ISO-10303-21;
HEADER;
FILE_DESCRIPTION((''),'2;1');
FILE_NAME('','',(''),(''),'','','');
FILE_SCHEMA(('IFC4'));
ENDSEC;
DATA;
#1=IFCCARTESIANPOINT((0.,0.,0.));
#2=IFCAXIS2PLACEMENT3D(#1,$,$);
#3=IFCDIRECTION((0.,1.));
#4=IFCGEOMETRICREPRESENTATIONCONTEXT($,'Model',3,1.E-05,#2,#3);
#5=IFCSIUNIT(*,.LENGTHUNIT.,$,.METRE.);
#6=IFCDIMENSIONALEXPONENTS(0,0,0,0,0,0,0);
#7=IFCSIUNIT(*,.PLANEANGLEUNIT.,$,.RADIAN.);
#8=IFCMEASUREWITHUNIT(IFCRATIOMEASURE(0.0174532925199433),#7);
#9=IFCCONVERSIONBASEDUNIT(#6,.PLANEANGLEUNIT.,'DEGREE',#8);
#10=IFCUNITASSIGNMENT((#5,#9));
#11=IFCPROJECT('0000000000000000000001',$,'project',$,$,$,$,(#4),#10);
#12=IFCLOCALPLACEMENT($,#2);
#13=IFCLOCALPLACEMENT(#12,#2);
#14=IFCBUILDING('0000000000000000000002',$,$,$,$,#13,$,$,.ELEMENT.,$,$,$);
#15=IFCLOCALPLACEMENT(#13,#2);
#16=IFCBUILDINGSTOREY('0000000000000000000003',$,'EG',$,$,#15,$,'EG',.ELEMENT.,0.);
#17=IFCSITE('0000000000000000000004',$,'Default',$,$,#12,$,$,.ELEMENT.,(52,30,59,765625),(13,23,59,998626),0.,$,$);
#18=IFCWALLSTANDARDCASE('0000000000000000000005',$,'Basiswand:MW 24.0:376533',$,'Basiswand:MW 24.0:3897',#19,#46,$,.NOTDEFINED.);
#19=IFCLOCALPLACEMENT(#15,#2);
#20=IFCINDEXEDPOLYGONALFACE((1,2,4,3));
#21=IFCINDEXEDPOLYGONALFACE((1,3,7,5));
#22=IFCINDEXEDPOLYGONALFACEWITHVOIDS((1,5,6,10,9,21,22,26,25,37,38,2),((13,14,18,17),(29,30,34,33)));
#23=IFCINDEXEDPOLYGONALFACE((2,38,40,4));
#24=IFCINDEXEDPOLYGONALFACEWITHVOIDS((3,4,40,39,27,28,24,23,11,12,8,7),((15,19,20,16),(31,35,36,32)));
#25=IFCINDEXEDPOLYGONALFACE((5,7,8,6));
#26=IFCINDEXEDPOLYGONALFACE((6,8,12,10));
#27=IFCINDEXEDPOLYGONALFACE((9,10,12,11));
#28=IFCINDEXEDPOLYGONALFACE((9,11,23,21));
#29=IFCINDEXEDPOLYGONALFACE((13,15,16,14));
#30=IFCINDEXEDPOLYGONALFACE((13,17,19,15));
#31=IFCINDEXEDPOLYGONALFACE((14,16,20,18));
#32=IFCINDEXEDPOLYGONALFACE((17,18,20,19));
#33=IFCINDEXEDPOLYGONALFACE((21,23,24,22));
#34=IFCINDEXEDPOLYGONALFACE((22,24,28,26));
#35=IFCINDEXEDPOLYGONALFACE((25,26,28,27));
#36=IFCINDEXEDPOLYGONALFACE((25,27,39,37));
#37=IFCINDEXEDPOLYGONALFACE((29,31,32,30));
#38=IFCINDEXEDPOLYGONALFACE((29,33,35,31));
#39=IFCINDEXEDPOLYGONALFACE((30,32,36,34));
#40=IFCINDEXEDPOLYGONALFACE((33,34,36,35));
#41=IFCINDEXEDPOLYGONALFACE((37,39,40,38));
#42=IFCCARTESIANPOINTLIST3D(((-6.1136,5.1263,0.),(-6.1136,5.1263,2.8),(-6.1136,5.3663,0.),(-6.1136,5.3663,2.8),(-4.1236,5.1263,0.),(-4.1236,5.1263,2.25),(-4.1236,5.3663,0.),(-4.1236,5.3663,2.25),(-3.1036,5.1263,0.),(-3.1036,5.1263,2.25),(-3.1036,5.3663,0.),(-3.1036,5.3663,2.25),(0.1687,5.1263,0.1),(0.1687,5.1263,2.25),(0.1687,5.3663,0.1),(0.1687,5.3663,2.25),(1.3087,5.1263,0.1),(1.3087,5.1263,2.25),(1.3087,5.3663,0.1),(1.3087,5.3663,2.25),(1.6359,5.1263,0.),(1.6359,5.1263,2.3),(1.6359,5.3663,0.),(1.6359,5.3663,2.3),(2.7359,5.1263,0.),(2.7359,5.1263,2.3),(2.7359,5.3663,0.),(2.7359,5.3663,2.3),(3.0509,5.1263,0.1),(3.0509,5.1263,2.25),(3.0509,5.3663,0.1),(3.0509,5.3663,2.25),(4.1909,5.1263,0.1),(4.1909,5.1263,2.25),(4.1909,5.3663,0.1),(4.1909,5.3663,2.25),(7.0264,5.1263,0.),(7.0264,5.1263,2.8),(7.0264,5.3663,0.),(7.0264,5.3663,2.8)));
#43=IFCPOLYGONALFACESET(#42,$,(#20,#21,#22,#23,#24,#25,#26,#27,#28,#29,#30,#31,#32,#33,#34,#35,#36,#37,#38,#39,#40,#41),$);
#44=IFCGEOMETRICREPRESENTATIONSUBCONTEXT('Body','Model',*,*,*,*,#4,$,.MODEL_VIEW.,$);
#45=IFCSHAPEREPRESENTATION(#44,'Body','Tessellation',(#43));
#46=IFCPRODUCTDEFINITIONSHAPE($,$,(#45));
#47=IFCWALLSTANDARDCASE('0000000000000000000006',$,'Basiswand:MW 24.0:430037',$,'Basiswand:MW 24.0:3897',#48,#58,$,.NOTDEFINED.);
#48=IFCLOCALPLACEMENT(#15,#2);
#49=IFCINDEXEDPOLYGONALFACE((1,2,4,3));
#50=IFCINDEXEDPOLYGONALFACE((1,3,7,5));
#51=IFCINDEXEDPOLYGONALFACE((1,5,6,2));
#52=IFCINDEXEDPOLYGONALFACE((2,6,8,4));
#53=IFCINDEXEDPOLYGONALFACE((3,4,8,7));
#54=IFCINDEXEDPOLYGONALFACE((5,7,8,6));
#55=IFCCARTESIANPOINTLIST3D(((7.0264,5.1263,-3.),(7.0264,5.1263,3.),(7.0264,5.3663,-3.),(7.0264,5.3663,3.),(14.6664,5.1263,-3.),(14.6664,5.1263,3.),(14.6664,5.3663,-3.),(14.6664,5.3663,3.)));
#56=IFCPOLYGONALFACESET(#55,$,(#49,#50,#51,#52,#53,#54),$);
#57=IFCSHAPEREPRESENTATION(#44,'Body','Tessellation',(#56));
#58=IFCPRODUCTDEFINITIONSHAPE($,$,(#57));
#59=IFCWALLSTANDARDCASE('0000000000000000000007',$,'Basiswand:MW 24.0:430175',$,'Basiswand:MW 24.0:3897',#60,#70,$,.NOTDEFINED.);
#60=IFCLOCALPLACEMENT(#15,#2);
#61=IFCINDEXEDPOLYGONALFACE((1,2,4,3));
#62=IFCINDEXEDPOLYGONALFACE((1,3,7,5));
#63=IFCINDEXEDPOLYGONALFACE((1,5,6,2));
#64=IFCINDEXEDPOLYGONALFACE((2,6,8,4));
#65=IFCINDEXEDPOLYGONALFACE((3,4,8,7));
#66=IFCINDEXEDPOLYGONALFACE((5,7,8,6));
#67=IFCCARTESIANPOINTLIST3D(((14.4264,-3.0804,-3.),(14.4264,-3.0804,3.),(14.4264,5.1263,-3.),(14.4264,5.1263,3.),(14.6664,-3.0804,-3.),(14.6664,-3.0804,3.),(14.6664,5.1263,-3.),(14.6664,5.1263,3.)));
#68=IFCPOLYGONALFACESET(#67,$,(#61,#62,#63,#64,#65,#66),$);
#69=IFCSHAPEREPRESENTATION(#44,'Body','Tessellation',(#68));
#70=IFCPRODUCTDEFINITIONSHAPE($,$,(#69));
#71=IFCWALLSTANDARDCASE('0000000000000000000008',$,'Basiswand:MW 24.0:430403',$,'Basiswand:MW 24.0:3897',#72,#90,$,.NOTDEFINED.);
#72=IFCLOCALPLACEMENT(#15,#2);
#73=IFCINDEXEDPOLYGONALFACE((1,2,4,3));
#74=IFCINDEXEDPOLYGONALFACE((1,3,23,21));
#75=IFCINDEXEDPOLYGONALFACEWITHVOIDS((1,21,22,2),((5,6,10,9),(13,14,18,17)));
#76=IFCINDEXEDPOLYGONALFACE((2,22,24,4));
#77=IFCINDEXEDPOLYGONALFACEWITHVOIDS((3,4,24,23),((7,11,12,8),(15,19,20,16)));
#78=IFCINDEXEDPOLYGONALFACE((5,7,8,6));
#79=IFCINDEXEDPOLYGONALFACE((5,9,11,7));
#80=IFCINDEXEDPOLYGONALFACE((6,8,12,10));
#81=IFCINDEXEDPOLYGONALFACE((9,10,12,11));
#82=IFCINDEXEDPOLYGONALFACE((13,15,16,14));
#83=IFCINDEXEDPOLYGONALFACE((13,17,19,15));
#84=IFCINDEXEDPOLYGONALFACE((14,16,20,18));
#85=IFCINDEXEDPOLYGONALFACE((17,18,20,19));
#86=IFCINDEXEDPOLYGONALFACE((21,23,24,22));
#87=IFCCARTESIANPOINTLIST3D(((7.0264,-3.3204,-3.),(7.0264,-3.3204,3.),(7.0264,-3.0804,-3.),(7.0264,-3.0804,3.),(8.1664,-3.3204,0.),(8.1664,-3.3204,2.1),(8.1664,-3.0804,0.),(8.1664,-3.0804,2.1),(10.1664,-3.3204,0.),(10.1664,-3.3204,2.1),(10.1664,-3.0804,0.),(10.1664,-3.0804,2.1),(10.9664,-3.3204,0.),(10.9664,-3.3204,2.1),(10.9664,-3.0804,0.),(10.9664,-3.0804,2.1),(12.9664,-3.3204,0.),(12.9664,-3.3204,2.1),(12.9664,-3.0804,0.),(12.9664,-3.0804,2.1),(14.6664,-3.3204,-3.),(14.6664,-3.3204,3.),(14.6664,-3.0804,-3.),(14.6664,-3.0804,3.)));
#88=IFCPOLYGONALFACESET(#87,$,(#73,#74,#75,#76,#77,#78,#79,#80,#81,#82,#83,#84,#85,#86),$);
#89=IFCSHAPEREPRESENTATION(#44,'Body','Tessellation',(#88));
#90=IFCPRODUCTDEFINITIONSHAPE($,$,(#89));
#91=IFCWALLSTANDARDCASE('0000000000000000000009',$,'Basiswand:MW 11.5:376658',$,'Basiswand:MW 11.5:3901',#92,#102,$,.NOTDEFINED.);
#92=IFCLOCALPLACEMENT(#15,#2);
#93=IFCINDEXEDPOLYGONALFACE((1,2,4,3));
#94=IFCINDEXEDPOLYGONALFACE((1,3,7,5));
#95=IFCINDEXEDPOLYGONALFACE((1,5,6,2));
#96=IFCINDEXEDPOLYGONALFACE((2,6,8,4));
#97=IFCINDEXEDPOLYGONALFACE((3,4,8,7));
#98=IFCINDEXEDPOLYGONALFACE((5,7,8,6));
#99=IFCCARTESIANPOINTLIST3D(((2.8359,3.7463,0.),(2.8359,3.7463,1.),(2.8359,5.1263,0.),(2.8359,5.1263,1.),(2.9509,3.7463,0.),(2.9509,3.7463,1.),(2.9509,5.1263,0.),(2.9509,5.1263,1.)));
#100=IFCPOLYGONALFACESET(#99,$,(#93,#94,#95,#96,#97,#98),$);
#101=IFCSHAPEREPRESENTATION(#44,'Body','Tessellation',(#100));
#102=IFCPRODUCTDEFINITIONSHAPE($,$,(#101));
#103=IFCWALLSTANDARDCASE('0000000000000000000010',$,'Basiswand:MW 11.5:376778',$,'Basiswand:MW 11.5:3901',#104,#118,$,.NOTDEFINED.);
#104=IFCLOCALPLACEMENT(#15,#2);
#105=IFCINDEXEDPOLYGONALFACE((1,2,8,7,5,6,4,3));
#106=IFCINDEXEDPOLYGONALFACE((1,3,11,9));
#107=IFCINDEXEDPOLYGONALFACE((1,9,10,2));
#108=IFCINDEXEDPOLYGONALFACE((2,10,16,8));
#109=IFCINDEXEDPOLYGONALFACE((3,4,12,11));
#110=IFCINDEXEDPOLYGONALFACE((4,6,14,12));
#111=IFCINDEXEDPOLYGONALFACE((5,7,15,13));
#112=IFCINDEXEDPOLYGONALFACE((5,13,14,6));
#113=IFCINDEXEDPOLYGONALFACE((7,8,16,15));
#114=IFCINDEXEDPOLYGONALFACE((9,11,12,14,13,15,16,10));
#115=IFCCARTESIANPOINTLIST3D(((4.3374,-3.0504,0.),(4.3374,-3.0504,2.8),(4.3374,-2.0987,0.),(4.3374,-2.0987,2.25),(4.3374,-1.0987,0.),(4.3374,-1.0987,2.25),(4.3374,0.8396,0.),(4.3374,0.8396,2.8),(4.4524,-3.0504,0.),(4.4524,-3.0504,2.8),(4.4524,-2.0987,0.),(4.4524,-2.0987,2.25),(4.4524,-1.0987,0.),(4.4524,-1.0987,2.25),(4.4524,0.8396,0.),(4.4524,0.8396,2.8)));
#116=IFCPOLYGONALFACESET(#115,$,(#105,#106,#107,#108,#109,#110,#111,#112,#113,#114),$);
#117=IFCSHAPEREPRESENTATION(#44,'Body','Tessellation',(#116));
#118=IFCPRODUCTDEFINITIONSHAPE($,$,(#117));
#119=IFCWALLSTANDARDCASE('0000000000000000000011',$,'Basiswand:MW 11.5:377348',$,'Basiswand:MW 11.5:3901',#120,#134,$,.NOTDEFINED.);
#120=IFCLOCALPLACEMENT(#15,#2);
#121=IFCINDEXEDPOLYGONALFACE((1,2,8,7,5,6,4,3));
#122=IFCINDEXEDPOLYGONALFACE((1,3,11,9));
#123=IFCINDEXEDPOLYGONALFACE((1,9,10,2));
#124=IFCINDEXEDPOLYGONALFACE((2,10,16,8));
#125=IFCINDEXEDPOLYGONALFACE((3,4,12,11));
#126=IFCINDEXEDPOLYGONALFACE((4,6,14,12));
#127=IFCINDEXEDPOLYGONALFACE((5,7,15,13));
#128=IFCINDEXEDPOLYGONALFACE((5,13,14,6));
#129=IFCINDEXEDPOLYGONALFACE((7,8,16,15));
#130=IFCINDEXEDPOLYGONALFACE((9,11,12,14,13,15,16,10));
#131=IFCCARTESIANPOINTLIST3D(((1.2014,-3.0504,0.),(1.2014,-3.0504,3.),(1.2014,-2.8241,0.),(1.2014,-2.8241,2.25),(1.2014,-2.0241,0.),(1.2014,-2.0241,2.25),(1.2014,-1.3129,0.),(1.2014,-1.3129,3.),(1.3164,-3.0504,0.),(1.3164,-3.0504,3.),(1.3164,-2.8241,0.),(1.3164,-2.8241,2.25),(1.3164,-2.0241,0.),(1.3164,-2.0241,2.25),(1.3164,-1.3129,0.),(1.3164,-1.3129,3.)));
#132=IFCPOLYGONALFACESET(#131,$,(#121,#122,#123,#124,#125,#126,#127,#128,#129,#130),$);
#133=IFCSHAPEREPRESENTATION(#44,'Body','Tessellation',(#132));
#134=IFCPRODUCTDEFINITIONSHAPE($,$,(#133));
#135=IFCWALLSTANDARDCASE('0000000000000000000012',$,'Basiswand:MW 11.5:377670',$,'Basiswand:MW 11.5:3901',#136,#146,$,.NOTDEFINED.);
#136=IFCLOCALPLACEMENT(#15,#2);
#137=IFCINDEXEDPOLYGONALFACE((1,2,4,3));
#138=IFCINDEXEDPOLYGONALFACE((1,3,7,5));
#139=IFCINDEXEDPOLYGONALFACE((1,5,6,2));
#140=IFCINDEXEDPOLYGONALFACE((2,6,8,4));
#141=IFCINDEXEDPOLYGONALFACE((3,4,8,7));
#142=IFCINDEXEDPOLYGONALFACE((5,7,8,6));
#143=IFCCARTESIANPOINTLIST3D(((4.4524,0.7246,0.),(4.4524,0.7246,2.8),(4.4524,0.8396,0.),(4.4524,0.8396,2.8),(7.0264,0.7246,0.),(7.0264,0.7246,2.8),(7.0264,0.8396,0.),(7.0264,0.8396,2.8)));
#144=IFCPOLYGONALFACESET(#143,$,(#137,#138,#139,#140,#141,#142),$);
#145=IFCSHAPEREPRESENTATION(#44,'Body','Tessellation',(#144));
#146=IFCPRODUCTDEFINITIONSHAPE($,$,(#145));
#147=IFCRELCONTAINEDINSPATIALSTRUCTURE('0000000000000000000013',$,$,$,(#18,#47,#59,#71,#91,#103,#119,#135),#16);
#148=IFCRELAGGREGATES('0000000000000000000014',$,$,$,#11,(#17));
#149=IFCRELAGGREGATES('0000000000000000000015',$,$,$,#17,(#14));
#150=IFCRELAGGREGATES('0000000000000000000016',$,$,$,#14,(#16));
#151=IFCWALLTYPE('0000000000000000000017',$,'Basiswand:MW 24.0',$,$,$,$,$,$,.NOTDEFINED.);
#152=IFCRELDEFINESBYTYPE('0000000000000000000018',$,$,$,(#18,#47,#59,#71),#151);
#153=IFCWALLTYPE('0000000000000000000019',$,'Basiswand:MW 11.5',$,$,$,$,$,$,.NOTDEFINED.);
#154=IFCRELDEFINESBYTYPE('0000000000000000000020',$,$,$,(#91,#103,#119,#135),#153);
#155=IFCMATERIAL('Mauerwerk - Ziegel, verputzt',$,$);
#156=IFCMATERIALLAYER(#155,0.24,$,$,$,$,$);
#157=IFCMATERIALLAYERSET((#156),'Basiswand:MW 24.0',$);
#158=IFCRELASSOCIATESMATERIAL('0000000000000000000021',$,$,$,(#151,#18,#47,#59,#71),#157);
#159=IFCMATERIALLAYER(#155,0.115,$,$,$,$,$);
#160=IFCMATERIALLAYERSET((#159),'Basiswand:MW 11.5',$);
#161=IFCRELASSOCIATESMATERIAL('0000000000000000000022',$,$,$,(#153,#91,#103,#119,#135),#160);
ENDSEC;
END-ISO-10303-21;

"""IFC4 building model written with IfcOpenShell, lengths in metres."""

from ifc_helpers import new_model, entity, si_unit, converted_unit, direction, frame, frame_2d, origin, place, context, subcontext, project, spatial, polyline, rectangle, extrude, clip, bounded_halfspace, material, layer, layer_set, layer_usage, type_object, element, save


model = new_model("IFC4")

# Units and contexts
model_context = context("Model", 3, precision=1e-05, world=origin(), true_north=direction((0.0, 1.0)))
body_context = subcontext(model_context, "Body", "Model", "MODEL_VIEW")
ifc_project = project(units=[si_unit("LENGTHUNIT", "METRE"), converted_unit("PLANEANGLEUNIT", "DEGREE", entity("IfcRatioMeasure", 0.0174532925199433), si_unit("PLANEANGLEUNIT", "RADIAN"), dimensions=[0, 0, 0, 0, 0, 0, 0])], contexts=[model_context])

# Site, building, storey
site_placement = place(None, origin())
site = spatial("IfcSite", under=ifc_project, at=site_placement, Name="Default", CompositionType="ELEMENT", RefLatitude=(52, 30, 59, 765625), RefLongitude=(13, 23, 59, 998626), RefElevation=0.0)
building_placement = place(site_placement, origin())
building = spatial("IfcBuilding", under=site, at=building_placement, CompositionType="ELEMENT")
storey_placement = place(building_placement, origin())
storey = spatial("IfcBuildingStorey", under=building, at=storey_placement, Name="EG", LongName="EG", CompositionType="ELEMENT", Elevation=0.0)

# Wall, openings
ifc_material = material(Name="Mauerwerk - Ziegel, verputzt")
ifc_layer_1 = layer(ifc_material, 0.24)
ifc_layer_set_1 = layer_set([ifc_layer_1], Name="Basiswand:MW 24.0")
ifc_layer_usage_1 = layer_usage(ifc_layer_set_1, "AXIS2", "NEGATIVE", 0.12)
wall_type_1 = type_object("IfcWallType", Name="Basiswand:MW 24.0", PredefinedType="NOTDEFINED", material=ifc_layer_set_1)
wall_1_placement = place(storey_placement, frame((7.0264, 5.2463, 0.0), z_axis=(0.0, 0.0, 1.0), x_axis=(-1.0, 0.0, 0.0)))
wall_1 = element("IfcWallStandardCase", 1, at=wall_1_placement, inside=storey, type_object=wall_type_1, material=ifc_layer_usage_1, Name="Basiswand:MW 24.0:376533", ObjectType="Basiswand:MW 24.0:3897", PredefinedType="NOTDEFINED", context=body_context, shape_type="Clipping", body=[
    clip(extrude(rectangle(XDim=13.14, YDim=0.24, at=frame_2d((6.57, 0.0), x_axis=(-1.0, 0.0))), origin(), (0.0, 0.0, 1.0), 2.8), bounded_halfspace(frame((0.0, -0.12, 2.8), z_axis=(0.0, 0.0, -1.0), x_axis=(0.0, 1.0, 0.0)), True, frame((0.0, -0.12, 2.8)), polyline([(0.0, 0.0), (13.14, 0.0), (13.14, 0.24), (8.71, 0.24), (8.535, 0.24), (0.0, 0.24), (0.0, 0.0)]))),
])
opening_1_placement = place(wall_1_placement, frame((4.2905, -0.12, 0.0)))
element("IfcOpeningElement", 2, at=opening_1_placement, cuts=wall_1, ObjectType="Opening", PredefinedType="OPENING", context=body_context, shape_type="SweptSolid", body=[
    extrude(rectangle(XDim=2.3, YDim=1.1, at=frame_2d((1.15, 0.55), x_axis=(1.0, 0.0))), frame((0.0, 0.0, 0.0), z_axis=(0.0, 1.0, 0.0), x_axis=(0.0, 0.0, 1.0)), (0.0, 0.0, 1.0), 0.24),
])
opening_2_placement = place(wall_1_placement, frame((10.13, -0.12, 0.0)))
element("IfcOpeningElement", 3, at=opening_2_placement, cuts=wall_1, ObjectType="Opening", PredefinedType="OPENING", context=body_context, shape_type="SweptSolid", body=[
    extrude(rectangle(XDim=2.25, YDim=1.02, at=frame_2d((1.125, 0.51), x_axis=(1.0, 0.0))), frame((0.0, 0.0, 0.0), z_axis=(0.0, 1.0, 0.0), x_axis=(0.0, 0.0, 1.0)), (0.0, 0.0, 1.0), 0.24),
])
opening_3_placement = place(wall_1_placement, frame((5.7178, -0.12, 0.1)))
element("IfcOpeningElement", 4, at=opening_3_placement, cuts=wall_1, ObjectType="Opening", PredefinedType="OPENING", context=body_context, shape_type="SweptSolid", body=[
    extrude(rectangle(XDim=2.15, YDim=1.14, at=frame_2d((1.075, 0.57), x_axis=(1.0, 0.0))), frame((0.0, 0.0, 0.0), z_axis=(0.0, 1.0, 0.0), x_axis=(0.0, 0.0, 1.0)), (0.0, 0.0, 1.0), 0.24),
])
opening_4_placement = place(wall_1_placement, frame((2.8355, -0.12, 0.1)))
element("IfcOpeningElement", 5, at=opening_4_placement, cuts=wall_1, ObjectType="Opening", PredefinedType="OPENING", context=body_context, shape_type="SweptSolid", body=[
    extrude(rectangle(XDim=2.15, YDim=1.14, at=frame_2d((1.075, 0.57), x_axis=(1.0, 0.0))), frame((0.0, 0.0, 0.0), z_axis=(0.0, 1.0, 0.0), x_axis=(0.0, 0.0, 1.0)), (0.0, 0.0, 1.0), 0.24),
])

# Walls
ifc_layer_usage_2 = layer_usage(ifc_layer_set_1, "AXIS2", "NEGATIVE", 0.12)
wall_2_placement = place(storey_placement, frame((7.0264, 5.2463, -3.0)))
element("IfcWallStandardCase", 6, at=wall_2_placement, inside=storey, type_object=wall_type_1, material=ifc_layer_usage_2, Name="Basiswand:MW 24.0:430037", ObjectType="Basiswand:MW 24.0:3897", PredefinedType="NOTDEFINED", context=body_context, shape_type="SweptSolid", body=[
    extrude(rectangle(XDim=7.64, YDim=0.24, at=frame_2d((3.82, 0.0), x_axis=(-1.0, 0.0))), origin(), (0.0, 0.0, 1.0), 6.0),
])
ifc_layer_usage_3 = layer_usage(ifc_layer_set_1, "AXIS2", "NEGATIVE", 0.12)
wall_3_placement = place(storey_placement, frame((14.5464, 5.1263, -3.0), z_axis=(0.0, 0.0, 1.0), x_axis=(0.0, -1.0, 0.0)))
element("IfcWallStandardCase", 7, at=wall_3_placement, inside=storey, type_object=wall_type_1, material=ifc_layer_usage_3, Name="Basiswand:MW 24.0:430175", ObjectType="Basiswand:MW 24.0:3897", PredefinedType="NOTDEFINED", context=body_context, shape_type="SweptSolid", body=[
    extrude(rectangle(XDim=8.2067, YDim=0.24, at=frame_2d((4.1034, 0.0), x_axis=(-1.0, 0.0))), origin(), (0.0, 0.0, 1.0), 6.0),
])

# Wall, openings
ifc_layer_usage_4 = layer_usage(ifc_layer_set_1, "AXIS2", "NEGATIVE", 0.12)
wall_4_placement = place(storey_placement, frame((14.6664, -3.2004, -3.0), z_axis=(0.0, 0.0, 1.0), x_axis=(-1.0, 0.0, 0.0)))
wall_4 = element("IfcWallStandardCase", 8, at=wall_4_placement, inside=storey, type_object=wall_type_1, material=ifc_layer_usage_4, Name="Basiswand:MW 24.0:430403", ObjectType="Basiswand:MW 24.0:3897", PredefinedType="NOTDEFINED", context=body_context, shape_type="SweptSolid", body=[
    extrude(rectangle(XDim=7.64, YDim=0.24, at=frame_2d((3.82, 0.0), x_axis=(-1.0, 0.0))), origin(), (0.0, 0.0, 1.0), 6.0),
])
opening_5_placement = place(wall_4_placement, frame((4.5, -0.12, 3.0)))
element("IfcOpeningElement", 9, at=opening_5_placement, cuts=wall_4, ObjectType="Opening", PredefinedType="OPENING", context=body_context, shape_type="SweptSolid", body=[
    extrude(rectangle(XDim=2.1, YDim=2.0, at=frame_2d((1.05, 1.0), x_axis=(1.0, 0.0))), frame((0.0, 0.0, 0.0), z_axis=(0.0, 1.0, 0.0), x_axis=(0.0, 0.0, 1.0)), (0.0, 0.0, 1.0), 0.24),
])
opening_6_placement = place(wall_4_placement, frame((1.7, -0.12, 3.0)))
element("IfcOpeningElement", 10, at=opening_6_placement, cuts=wall_4, ObjectType="Opening", PredefinedType="OPENING", context=body_context, shape_type="SweptSolid", body=[
    extrude(rectangle(XDim=2.1, YDim=2.0, at=frame_2d((1.05, 1.0), x_axis=(1.0, 0.0))), frame((0.0, 0.0, 0.0), z_axis=(0.0, 1.0, 0.0), x_axis=(0.0, 0.0, 1.0)), (0.0, 0.0, 1.0), 0.24),
])

# Wall
ifc_layer_2 = layer(ifc_material, 0.115)
ifc_layer_set_2 = layer_set([ifc_layer_2], Name="Basiswand:MW 11.5")
ifc_layer_usage_5 = layer_usage(ifc_layer_set_2, "AXIS2", "NEGATIVE", 0.0575)
wall_type_2 = type_object("IfcWallType", Name="Basiswand:MW 11.5", PredefinedType="NOTDEFINED", material=ifc_layer_set_2)
wall_5_placement = place(storey_placement, frame((2.8934, 5.1263, 0.0), z_axis=(0.0, 0.0, 1.0), x_axis=(0.0, -1.0, 0.0)))
element("IfcWallStandardCase", 11, at=wall_5_placement, inside=storey, type_object=wall_type_2, material=ifc_layer_usage_5, Name="Basiswand:MW 11.5:376658", ObjectType="Basiswand:MW 11.5:3901", PredefinedType="NOTDEFINED", context=body_context, shape_type="SweptSolid", body=[
    extrude(rectangle(XDim=1.38, YDim=0.115, at=frame_2d((0.69, 0.0), x_axis=(-1.0, 0.0))), origin(), (0.0, 0.0, 1.0), 1.0),
])

# Walls, openings
ifc_layer_usage_6 = layer_usage(ifc_layer_set_2, "AXIS2", "NEGATIVE", 0.0575)
wall_6_placement = place(storey_placement, frame((4.3949, -3.0504, 0.0), z_axis=(0.0, 0.0, 1.0), x_axis=(0.0, 1.0, 0.0)))
wall_6 = element("IfcWallStandardCase", 12, at=wall_6_placement, inside=storey, type_object=wall_type_2, material=ifc_layer_usage_6, Name="Basiswand:MW 11.5:376778", ObjectType="Basiswand:MW 11.5:3901", PredefinedType="NOTDEFINED", context=body_context, shape_type="Clipping", body=[
    clip(extrude(rectangle(XDim=3.89, YDim=0.115, at=frame_2d((1.945, 0.0), x_axis=(-1.0, 0.0))), origin(), (0.0, 0.0, 1.0), 2.8), bounded_halfspace(frame((0.0, -0.0575, 2.8), z_axis=(0.0, 0.0, -1.0), x_axis=(-1.0, 0.0, 0.0)), True, frame((0.0, -0.0575, 2.8)), polyline([(0.0, 0.0), (3.775, 0.0), (3.89, 0.0), (3.89, 0.115), (0.0, 0.115), (0.0, 0.0)]))),
])
opening_7_placement = place(wall_6_placement, frame((1.9517, 0.0575, 0.0)))
element("IfcOpeningElement", 13, at=opening_7_placement, cuts=wall_6, ObjectType="Opening", PredefinedType="OPENING", context=body_context, shape_type="SweptSolid", body=[
    extrude(rectangle(XDim=2.25, YDim=1.0, at=frame_2d((1.125, 0.5), x_axis=(1.0, 0.0))), frame((0.0, 0.0, 0.0), z_axis=(0.0, -1.0, 0.0), x_axis=(0.0, 0.0, 1.0)), (0.0, 0.0, 1.0), 0.115),
])
ifc_layer_usage_7 = layer_usage(ifc_layer_set_2, "AXIS2", "POSITIVE", -0.0575)
wall_7_placement = place(storey_placement, frame((1.2589, -3.0504, 0.0), z_axis=(0.0, 0.0, 1.0), x_axis=(0.0, 1.0, 0.0)))
wall_7 = element("IfcWallStandardCase", 14, at=wall_7_placement, inside=storey, type_object=wall_type_2, material=ifc_layer_usage_7, Name="Basiswand:MW 11.5:377348", ObjectType="Basiswand:MW 11.5:3901", PredefinedType="NOTDEFINED", context=body_context, shape_type="SweptSolid", body=[
    extrude(rectangle(XDim=1.7375, YDim=0.115, at=frame_2d((0.8688, 0.0), x_axis=(-1.0, 0.0))), origin(), (0.0, 0.0, 1.0), 3.0),
])
opening_8_placement = place(wall_7_placement, frame((0.2263, -0.0575, 0.0)))
element("IfcOpeningElement", 15, at=opening_8_placement, cuts=wall_7, ObjectType="Opening", PredefinedType="OPENING", context=body_context, shape_type="SweptSolid", body=[
    extrude(rectangle(XDim=2.25, YDim=0.8, at=frame_2d((1.125, 0.4), x_axis=(1.0, 0.0))), frame((0.0, 0.0, 0.0), z_axis=(0.0, 1.0, 0.0), x_axis=(0.0, 0.0, 1.0)), (0.0, 0.0, 1.0), 0.115),
])

# Wall
ifc_layer_usage_8 = layer_usage(ifc_layer_set_2, "AXIS2", "NEGATIVE", 0.0575)
wall_8_placement = place(storey_placement, frame((7.0264, 0.7821, 0.0), z_axis=(0.0, 0.0, 1.0), x_axis=(-1.0, 0.0, 0.0)))
element("IfcWallStandardCase", 16, at=wall_8_placement, inside=storey, type_object=wall_type_2, material=ifc_layer_usage_8, Name="Basiswand:MW 11.5:377670", ObjectType="Basiswand:MW 11.5:3901", PredefinedType="NOTDEFINED", context=body_context, shape_type="Clipping", body=[
    clip(extrude(rectangle(XDim=2.574, YDim=0.115, at=frame_2d((1.287, 0.0), x_axis=(-1.0, 0.0))), origin(), (0.0, 0.0, 1.0), 2.8), bounded_halfspace(frame((0.0, -0.0575, 2.8), z_axis=(0.0, 0.0, -1.0), x_axis=(0.0, 1.0, 0.0)), True, frame((0.0, -0.0575, 2.8)), polyline([(0.0, 0.0), (2.574, 0.0), (2.574, 0.115), (0.0, 0.115), (0.0, 0.0)]))),
])

save(model, "model.ifc")
